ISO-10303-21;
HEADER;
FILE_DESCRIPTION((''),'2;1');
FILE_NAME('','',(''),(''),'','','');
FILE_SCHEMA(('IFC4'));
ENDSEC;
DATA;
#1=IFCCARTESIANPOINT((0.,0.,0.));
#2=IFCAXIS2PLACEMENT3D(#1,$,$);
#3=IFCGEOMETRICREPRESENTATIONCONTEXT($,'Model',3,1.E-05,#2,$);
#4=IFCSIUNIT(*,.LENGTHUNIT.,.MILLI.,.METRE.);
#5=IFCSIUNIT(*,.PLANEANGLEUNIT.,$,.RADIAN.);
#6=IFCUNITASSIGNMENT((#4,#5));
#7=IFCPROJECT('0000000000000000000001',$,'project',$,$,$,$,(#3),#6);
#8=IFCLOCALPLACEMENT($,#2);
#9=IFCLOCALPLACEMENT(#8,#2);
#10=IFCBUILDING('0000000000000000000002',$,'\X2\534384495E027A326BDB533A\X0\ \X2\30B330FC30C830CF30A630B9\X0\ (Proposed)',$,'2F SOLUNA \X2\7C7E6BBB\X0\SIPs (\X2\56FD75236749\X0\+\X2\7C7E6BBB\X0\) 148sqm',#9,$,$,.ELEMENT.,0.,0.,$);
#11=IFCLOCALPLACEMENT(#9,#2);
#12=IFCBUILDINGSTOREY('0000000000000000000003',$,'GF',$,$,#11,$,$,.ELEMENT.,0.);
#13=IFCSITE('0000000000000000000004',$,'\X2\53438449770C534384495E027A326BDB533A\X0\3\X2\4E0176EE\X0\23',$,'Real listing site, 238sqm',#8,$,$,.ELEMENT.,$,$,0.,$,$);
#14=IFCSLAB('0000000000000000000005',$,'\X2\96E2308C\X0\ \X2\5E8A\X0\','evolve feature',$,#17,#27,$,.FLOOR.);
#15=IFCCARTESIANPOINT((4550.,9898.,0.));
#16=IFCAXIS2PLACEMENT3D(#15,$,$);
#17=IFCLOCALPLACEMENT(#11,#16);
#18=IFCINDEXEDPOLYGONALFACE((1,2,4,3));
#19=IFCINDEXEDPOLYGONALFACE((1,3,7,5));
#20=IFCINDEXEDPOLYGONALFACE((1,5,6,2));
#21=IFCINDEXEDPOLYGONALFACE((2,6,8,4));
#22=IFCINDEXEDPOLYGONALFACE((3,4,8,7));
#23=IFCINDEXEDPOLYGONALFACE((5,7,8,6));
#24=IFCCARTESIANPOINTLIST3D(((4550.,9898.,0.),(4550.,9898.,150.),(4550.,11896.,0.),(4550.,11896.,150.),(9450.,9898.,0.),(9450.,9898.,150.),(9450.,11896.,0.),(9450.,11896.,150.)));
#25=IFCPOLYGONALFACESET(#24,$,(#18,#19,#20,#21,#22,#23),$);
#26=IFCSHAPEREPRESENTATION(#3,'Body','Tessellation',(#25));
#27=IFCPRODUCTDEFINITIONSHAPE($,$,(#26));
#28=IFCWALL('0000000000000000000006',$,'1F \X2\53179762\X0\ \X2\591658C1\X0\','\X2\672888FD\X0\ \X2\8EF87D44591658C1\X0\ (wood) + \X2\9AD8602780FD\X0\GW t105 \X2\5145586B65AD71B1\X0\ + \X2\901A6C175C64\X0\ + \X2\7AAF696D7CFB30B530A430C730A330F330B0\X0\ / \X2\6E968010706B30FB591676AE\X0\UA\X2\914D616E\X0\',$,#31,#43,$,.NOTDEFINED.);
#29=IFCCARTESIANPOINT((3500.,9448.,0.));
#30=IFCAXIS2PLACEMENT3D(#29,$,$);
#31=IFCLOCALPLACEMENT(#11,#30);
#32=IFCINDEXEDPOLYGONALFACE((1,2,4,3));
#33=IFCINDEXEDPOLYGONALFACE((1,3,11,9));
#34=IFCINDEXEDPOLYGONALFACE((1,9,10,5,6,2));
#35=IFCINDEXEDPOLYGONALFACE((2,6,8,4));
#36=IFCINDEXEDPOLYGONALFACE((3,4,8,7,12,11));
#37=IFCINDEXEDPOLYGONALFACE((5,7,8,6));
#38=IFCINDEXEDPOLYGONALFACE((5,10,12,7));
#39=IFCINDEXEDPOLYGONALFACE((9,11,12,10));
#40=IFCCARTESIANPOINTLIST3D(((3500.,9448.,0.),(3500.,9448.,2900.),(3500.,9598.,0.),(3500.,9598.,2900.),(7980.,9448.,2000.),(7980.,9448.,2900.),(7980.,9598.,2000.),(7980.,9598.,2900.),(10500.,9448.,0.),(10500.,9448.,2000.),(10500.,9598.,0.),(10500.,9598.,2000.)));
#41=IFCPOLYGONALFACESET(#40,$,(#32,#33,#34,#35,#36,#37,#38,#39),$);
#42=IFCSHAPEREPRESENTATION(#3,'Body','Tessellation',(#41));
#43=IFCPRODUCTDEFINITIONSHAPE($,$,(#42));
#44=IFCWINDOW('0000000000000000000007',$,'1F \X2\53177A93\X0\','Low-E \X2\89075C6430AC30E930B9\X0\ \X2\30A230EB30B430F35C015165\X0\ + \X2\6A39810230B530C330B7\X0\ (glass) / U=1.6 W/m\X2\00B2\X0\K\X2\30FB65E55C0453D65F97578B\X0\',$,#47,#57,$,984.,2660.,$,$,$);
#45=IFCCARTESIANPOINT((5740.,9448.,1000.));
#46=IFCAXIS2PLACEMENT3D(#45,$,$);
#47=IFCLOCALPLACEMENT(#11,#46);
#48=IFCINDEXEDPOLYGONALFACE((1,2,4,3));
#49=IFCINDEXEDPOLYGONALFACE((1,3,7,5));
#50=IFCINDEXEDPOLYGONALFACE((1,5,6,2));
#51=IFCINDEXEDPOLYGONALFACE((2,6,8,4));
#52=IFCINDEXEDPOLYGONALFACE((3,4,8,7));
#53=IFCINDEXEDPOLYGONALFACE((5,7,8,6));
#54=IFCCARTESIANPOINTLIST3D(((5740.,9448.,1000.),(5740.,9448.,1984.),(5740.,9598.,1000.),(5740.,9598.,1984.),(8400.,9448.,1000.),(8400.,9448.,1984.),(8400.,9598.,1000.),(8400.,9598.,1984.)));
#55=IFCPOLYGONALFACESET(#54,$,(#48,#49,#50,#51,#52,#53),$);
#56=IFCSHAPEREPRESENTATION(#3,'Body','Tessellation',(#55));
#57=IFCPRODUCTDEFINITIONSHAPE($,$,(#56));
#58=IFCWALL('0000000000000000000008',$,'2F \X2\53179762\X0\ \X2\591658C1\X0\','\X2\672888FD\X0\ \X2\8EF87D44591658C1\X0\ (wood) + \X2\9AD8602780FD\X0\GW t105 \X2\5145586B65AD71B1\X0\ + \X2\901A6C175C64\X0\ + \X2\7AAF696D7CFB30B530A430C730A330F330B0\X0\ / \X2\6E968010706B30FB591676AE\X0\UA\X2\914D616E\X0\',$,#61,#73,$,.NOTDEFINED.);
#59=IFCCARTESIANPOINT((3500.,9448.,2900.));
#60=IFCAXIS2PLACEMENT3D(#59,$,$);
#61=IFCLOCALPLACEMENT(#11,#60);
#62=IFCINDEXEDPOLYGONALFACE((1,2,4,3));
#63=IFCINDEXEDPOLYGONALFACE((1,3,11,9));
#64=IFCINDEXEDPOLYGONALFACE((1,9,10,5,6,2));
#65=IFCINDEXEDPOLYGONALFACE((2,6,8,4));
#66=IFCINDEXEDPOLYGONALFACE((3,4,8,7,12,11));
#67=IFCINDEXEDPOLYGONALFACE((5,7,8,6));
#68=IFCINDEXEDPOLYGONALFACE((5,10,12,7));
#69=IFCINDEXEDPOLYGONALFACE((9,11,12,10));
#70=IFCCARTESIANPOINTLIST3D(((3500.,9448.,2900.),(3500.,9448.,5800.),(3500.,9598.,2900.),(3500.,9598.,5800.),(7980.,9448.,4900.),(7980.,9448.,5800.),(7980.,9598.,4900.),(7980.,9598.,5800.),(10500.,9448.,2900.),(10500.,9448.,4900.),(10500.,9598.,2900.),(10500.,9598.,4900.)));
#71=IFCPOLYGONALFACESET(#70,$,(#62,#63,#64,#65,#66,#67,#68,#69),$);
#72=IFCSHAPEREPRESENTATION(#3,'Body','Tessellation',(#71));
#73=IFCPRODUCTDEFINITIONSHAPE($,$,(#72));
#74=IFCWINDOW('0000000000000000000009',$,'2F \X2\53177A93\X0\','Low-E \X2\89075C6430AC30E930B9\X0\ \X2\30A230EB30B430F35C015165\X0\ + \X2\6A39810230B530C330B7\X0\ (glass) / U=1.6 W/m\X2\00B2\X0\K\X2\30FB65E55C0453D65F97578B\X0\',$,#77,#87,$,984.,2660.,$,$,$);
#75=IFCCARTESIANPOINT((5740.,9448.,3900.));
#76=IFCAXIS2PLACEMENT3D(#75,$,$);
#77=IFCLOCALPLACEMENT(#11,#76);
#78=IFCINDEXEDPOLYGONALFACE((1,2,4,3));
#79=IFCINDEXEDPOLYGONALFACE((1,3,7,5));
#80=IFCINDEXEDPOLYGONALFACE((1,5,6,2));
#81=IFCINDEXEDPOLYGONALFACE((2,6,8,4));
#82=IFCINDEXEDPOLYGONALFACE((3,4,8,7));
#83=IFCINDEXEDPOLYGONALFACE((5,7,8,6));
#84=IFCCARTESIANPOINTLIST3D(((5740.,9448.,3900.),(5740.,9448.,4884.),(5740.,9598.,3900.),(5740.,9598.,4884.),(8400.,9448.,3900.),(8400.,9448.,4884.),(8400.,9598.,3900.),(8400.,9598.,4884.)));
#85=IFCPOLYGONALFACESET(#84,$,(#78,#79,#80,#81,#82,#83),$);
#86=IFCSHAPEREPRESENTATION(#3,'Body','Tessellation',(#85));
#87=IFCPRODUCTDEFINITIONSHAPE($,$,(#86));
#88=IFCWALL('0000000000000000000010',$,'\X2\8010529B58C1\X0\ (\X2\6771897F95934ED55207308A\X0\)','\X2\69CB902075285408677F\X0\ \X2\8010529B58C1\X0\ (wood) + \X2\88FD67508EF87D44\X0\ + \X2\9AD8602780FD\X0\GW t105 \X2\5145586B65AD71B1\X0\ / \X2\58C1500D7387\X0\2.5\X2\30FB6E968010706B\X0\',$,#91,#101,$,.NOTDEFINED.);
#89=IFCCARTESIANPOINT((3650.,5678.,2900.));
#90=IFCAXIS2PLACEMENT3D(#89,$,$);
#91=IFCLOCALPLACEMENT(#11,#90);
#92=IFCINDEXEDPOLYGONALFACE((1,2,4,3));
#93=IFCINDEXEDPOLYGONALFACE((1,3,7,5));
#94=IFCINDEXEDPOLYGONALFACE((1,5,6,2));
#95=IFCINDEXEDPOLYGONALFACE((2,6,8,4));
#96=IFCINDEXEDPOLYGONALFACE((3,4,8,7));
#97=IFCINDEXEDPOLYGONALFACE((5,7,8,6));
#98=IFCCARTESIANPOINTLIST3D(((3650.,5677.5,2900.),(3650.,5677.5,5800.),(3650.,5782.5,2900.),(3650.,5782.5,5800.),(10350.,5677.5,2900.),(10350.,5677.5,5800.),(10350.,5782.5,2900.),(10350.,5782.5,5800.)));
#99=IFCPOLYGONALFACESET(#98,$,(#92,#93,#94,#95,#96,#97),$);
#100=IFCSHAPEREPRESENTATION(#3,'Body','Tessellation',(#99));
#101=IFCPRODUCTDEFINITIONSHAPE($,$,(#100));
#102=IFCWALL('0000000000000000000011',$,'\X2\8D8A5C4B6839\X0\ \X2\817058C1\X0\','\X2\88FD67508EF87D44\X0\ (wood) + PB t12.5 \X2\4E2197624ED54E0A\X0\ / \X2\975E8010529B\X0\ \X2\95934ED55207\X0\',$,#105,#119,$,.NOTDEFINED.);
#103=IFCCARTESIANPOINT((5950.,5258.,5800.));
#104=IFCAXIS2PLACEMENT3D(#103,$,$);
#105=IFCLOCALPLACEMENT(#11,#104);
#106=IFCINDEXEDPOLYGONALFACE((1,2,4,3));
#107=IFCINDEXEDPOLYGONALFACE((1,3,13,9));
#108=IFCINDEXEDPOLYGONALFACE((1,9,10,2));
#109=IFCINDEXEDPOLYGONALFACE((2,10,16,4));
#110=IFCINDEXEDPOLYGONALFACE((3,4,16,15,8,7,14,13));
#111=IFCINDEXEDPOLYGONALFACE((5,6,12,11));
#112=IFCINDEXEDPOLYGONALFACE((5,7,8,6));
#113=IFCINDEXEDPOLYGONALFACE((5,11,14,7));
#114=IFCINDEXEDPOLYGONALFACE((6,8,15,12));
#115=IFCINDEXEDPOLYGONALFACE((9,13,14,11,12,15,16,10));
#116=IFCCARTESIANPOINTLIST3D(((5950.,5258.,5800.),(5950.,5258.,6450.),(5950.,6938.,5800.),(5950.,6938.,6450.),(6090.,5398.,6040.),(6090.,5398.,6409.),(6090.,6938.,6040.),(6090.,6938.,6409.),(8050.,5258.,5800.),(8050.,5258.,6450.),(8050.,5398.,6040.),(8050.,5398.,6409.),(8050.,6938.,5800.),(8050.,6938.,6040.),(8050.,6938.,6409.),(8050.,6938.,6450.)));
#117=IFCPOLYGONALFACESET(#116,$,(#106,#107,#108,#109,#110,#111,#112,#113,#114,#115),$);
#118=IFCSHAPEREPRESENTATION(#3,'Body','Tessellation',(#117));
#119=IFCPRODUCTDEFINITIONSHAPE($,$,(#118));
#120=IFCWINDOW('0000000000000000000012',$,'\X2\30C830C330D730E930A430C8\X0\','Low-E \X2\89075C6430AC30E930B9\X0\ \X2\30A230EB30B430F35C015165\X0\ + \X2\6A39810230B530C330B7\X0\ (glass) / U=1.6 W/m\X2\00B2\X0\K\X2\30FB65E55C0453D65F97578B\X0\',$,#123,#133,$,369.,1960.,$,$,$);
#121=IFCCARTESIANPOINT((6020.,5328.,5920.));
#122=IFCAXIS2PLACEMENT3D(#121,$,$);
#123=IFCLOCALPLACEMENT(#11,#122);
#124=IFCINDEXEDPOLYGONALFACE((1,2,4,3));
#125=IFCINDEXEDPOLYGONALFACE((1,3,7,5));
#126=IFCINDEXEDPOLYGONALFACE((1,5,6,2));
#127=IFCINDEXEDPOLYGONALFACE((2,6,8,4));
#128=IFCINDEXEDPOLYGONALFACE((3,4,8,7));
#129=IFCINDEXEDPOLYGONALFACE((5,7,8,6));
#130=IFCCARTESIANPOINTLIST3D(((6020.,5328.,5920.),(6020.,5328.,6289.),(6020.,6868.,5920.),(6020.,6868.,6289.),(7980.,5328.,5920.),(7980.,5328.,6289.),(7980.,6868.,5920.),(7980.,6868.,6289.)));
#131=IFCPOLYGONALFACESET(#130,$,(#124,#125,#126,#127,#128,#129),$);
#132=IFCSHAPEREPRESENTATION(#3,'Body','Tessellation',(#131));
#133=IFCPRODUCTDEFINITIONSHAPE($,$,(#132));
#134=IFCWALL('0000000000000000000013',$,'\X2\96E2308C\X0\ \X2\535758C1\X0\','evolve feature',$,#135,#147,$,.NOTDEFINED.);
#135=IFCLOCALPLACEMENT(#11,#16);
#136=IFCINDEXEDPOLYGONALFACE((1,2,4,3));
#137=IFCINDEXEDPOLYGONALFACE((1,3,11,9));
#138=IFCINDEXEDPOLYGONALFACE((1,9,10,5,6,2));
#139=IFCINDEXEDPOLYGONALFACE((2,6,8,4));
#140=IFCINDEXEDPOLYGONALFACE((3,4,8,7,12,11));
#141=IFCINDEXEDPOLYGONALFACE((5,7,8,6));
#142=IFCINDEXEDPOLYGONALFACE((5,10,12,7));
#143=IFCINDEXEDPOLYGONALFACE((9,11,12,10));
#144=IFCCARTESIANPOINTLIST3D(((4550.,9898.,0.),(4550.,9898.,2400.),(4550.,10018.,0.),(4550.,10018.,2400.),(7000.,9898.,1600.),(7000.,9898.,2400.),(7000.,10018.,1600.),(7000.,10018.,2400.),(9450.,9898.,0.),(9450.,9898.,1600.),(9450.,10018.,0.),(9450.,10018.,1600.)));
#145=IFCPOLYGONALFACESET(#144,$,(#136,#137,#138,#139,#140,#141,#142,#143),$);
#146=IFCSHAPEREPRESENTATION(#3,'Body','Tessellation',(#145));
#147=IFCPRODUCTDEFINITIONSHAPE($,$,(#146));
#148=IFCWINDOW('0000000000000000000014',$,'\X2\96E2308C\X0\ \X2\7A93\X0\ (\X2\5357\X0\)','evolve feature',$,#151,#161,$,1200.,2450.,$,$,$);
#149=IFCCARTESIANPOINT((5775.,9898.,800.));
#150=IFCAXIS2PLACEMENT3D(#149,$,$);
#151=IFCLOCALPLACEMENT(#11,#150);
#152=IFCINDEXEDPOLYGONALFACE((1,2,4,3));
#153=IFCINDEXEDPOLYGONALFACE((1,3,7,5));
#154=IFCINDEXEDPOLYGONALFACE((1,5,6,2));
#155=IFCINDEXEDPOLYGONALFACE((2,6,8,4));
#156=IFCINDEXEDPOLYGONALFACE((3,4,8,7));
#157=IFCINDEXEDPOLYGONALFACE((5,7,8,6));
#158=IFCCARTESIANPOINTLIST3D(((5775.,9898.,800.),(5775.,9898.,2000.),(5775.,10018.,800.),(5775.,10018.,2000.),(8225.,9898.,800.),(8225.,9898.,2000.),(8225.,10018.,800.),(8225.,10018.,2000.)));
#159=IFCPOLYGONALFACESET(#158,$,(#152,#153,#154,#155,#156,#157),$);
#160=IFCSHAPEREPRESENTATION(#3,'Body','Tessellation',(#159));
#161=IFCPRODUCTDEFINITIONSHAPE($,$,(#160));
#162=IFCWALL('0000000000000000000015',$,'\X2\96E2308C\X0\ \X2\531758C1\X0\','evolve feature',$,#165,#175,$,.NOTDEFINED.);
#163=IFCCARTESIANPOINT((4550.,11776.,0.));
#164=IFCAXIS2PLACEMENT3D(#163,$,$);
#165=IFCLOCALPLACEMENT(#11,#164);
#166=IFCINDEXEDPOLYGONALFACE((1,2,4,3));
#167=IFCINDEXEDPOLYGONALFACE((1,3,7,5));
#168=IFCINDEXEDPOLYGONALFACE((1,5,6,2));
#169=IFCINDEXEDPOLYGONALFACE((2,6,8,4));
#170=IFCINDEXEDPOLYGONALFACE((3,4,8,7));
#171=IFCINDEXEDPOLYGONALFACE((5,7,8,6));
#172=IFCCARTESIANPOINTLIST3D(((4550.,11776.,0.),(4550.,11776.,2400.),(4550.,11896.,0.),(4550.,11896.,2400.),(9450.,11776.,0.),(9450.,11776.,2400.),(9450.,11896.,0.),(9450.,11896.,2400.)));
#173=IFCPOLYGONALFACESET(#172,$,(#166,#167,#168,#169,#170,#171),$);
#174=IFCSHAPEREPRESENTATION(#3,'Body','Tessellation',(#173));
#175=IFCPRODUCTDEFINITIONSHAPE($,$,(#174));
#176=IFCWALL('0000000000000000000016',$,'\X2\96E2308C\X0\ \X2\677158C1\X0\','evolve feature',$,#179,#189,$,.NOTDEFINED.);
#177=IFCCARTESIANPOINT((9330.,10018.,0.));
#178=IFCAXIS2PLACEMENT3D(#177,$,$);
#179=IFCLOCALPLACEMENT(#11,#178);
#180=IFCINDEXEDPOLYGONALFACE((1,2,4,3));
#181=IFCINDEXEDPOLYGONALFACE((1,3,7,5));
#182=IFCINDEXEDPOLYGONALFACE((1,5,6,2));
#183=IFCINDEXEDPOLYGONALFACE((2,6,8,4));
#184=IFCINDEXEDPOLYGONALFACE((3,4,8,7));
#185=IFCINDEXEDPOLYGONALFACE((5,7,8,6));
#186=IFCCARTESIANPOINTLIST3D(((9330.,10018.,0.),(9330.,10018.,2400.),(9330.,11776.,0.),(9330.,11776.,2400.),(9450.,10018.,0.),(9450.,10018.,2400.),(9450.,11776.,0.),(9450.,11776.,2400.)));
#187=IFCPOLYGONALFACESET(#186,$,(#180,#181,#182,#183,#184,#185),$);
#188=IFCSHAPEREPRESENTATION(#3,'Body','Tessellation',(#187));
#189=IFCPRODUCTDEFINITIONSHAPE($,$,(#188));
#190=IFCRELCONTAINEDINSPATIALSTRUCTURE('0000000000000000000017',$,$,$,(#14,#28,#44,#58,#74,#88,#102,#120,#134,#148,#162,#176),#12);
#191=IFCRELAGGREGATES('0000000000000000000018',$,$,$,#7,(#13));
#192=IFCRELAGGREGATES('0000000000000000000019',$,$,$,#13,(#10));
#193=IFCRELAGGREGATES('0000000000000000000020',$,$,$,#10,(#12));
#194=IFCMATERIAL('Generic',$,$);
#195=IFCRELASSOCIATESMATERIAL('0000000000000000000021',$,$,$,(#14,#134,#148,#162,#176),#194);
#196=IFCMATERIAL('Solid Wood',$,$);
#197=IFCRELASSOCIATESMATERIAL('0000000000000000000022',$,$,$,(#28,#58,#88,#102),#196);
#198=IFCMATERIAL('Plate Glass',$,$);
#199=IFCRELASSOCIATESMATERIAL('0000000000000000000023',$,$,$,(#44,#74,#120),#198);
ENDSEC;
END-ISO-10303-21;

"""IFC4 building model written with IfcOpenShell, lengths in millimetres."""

from ifc_helpers import new_model, si_unit, frame, frame_2d, origin, place, context, project, spatial, rectangle, extrude, material, element, fill, save


model = new_model("IFC4")

# Units and contexts
model_context = context("Model", 3, precision=1e-05, world=origin())
ifc_project = project(units=[si_unit("LENGTHUNIT", "METRE", prefix="MILLI"), si_unit("PLANEANGLEUNIT", "RADIAN")], contexts=[model_context])

# Site, building, storey
site_placement = place(None, origin())
site = spatial("IfcSite", under=ifc_project, at=site_placement, Name="千葉県千葉市稲毛区3丁目23", ObjectType="Real listing site, 238sqm", CompositionType="ELEMENT", RefElevation=0.0)
building_placement = place(site_placement, origin())
building = spatial("IfcBuilding", under=site, at=building_placement, Name="千葉市稲毛区 コートハウス (Proposed)", ObjectType="2F SOLUNA 籾殻SIPs (国産杉+籾殻) 148sqm", CompositionType="ELEMENT", ElevationOfRefHeight=0.0, ElevationOfTerrain=0.0)
storey_placement = place(building_placement, origin())
storey = spatial("IfcBuildingStorey", under=building, at=storey_placement, Name="GF", CompositionType="ELEMENT", Elevation=0.0)

# Slab
ifc_material_1 = material(Name="Generic")
slab_placement = place(storey_placement, frame((4550.0, 9898.0, 0.0)))
element("IfcSlab", 1, at=slab_placement, inside=storey, material=ifc_material_1, Name="離れ 床", Description="evolve feature", PredefinedType="FLOOR", context=model_context, shape_type="SweptSolid", body=[
    extrude(rectangle(XDim=4900.0, YDim=1998.0, at=frame_2d((2450.0, 999.0))), frame((4550.0, 9898.0, 0.0)), (0.0, 0.0, 1.0), 150.0),
])

# Wall, opening, window
ifc_material_2 = material(Name="Solid Wood")
wall_1_placement = place(storey_placement, frame((3500.0, 9448.0, 0.0)))
wall_1 = element("IfcWall", 2, at=wall_1_placement, inside=storey, material=ifc_material_2, Name="1F 北面 外壁", Description="木製 軸組外壁 (wood) + 高性能GW t105 充填断熱 + 通気層 + 窯業系サイディング / 準耐火・外皮UA配慮", PredefinedType="NOTDEFINED", context=model_context, shape_type="SweptSolid", body=[
    extrude(rectangle(XDim=7000.0, YDim=150.0, at=frame_2d((3500.0, 75.0))), frame((3500.0, 9448.0, 0.0)), (0.0, 0.0, 1.0), 2900.0),
])
opening_1_placement = place(storey_placement, frame((5740.0, 9448.0, 1000.0)))
opening_1 = element("IfcOpeningElement", 3, at=opening_1_placement, cuts=wall_1, PredefinedType="NOTDEFINED", context=model_context, shape_type="SweptSolid", body=[
    extrude(rectangle(XDim=2660.0, YDim=150.0, at=frame_2d((1330.0, 75.0))), frame((5740.0, 9448.0, 1000.0)), (0.0, 0.0, 1.0), 984.0),
])
ifc_material_3 = material(Name="Plate Glass")
window_1_placement = place(storey_placement, frame((5740.0, 9448.0, 1000.0)))
window_1 = element("IfcWindow", 4, at=window_1_placement, inside=storey, material=ifc_material_3, Name="1F 北窓", Description="Low-E 複層ガラス アルゴン封入 + 樹脂サッシ (glass) / U=1.6 W/m²K・日射取得型", OverallHeight=984.0, OverallWidth=2660.0, context=model_context, shape_type="SweptSolid", body=[
    extrude(rectangle(XDim=2660.0, YDim=150.0, at=frame_2d((1330.0, 75.0))), frame((5740.0, 9448.0, 1000.0)), (0.0, 0.0, 1.0), 984.0),
])
fill(opening_1, window_1)

# Wall, opening, window
wall_2_placement = place(storey_placement, frame((3500.0, 9448.0, 2900.0)))
wall_2 = element("IfcWall", 5, at=wall_2_placement, inside=storey, material=ifc_material_2, Name="2F 北面 外壁", Description="木製 軸組外壁 (wood) + 高性能GW t105 充填断熱 + 通気層 + 窯業系サイディング / 準耐火・外皮UA配慮", PredefinedType="NOTDEFINED", context=model_context, shape_type="SweptSolid", body=[
    extrude(rectangle(XDim=7000.0, YDim=150.0, at=frame_2d((3500.0, 75.0))), frame((3500.0, 9448.0, 2900.0)), (0.0, 0.0, 1.0), 2900.0),
])
opening_2_placement = place(storey_placement, frame((5740.0, 9448.0, 3900.0)))
opening_2 = element("IfcOpeningElement", 6, at=opening_2_placement, cuts=wall_2, PredefinedType="NOTDEFINED", context=model_context, shape_type="SweptSolid", body=[
    extrude(rectangle(XDim=2660.0, YDim=150.0, at=frame_2d((1330.0, 75.0))), frame((5740.0, 9448.0, 3900.0)), (0.0, 0.0, 1.0), 984.0),
])
window_2_placement = place(storey_placement, frame((5740.0, 9448.0, 3900.0)))
window_2 = element("IfcWindow", 7, at=window_2_placement, inside=storey, material=ifc_material_3, Name="2F 北窓", Description="Low-E 複層ガラス アルゴン封入 + 樹脂サッシ (glass) / U=1.6 W/m²K・日射取得型", OverallHeight=984.0, OverallWidth=2660.0, context=model_context, shape_type="SweptSolid", body=[
    extrude(rectangle(XDim=2660.0, YDim=150.0, at=frame_2d((1330.0, 75.0))), frame((5740.0, 9448.0, 3900.0)), (0.0, 0.0, 1.0), 984.0),
])
fill(opening_2, window_2)

# Wall
wall_3_placement = place(storey_placement, frame((3650.0, 5678.0, 2900.0)))
element("IfcWall", 8, at=wall_3_placement, inside=storey, material=ifc_material_2, Name="耐力壁 (東西間仕切り)", Description="構造用合板 耐力壁 (wood) + 製材軸組 + 高性能GW t105 充填断熱 / 壁倍率2.5・準耐火", PredefinedType="NOTDEFINED", context=model_context, shape_type="SweptSolid", body=[
    extrude(rectangle(XDim=6700.0, YDim=105.0, at=frame_2d((3350.0, 52.0))), frame((3650.0, 5678.0, 2900.0)), (0.0, 0.0, 1.0), 2900.0),
])

# Walls, openings, windows
wall_4_placement = place(storey_placement, frame((5950.0, 5258.0, 5800.0)))
wall_4 = element("IfcWall", 9, at=wall_4_placement, inside=storey, material=ifc_material_2, Name="越屋根 腰壁", Description="製材軸組 (wood) + PB t12.5 両面仕上 / 非耐力 間仕切", PredefinedType="NOTDEFINED", context=model_context, shape_type="SweptSolid", body=[
    extrude(rectangle(XDim=2100.0, YDim=1680.0, at=frame_2d((1050.0, 840.0))), frame((5950.0, 5258.0, 5800.0)), (0.0, 0.0, 1.0), 650.0),
])
opening_3_placement = place(storey_placement, frame((6020.0, 5328.0, 5920.0)))
opening_3 = element("IfcOpeningElement", 10, at=opening_3_placement, cuts=wall_4, PredefinedType="NOTDEFINED", context=model_context, shape_type="SweptSolid", body=[
    extrude(rectangle(XDim=1960.0, YDim=1540.0, at=frame_2d((980.0, 770.0))), frame((6020.0, 5328.0, 5920.0)), (0.0, 0.0, 1.0), 369.0),
])
window_3_placement = place(storey_placement, frame((6020.0, 5328.0, 5920.0)))
window_3 = element("IfcWindow", 11, at=window_3_placement, inside=storey, material=ifc_material_3, Name="トップライト", Description="Low-E 複層ガラス アルゴン封入 + 樹脂サッシ (glass) / U=1.6 W/m²K・日射取得型", OverallHeight=369.0, OverallWidth=1960.0, context=model_context, shape_type="SweptSolid", body=[
    extrude(rectangle(XDim=1960.0, YDim=1540.0, at=frame_2d((980.0, 770.0))), frame((6020.0, 5328.0, 5920.0)), (0.0, 0.0, 1.0), 369.0),
])
fill(opening_3, window_3)
wall_5_placement = place(storey_placement, frame((4550.0, 9898.0, 0.0)))
wall_5 = element("IfcWall", 12, at=wall_5_placement, inside=storey, material=ifc_material_1, Name="離れ 南壁", Description="evolve feature", PredefinedType="NOTDEFINED", context=model_context, shape_type="SweptSolid", body=[
    extrude(rectangle(XDim=4900.0, YDim=120.0, at=frame_2d((2450.0, 60.0))), frame((4550.0, 9898.0, 0.0)), (0.0, 0.0, 1.0), 2400.0),
])
opening_4_placement = place(storey_placement, frame((5775.0, 9898.0, 800.0)))
opening_4 = element("IfcOpeningElement", 13, at=opening_4_placement, cuts=wall_5, PredefinedType="NOTDEFINED", context=model_context, shape_type="SweptSolid", body=[
    extrude(rectangle(XDim=2450.0, YDim=120.0, at=frame_2d((1225.0, 60.0))), frame((5775.0, 9898.0, 800.0)), (0.0, 0.0, 1.0), 1200.0),
])
window_4_placement = place(storey_placement, frame((5775.0, 9898.0, 800.0)))
window_4 = element("IfcWindow", 14, at=window_4_placement, inside=storey, material=ifc_material_1, Name="離れ 窓 (南)", Description="evolve feature", OverallHeight=1200.0, OverallWidth=2450.0, context=model_context, shape_type="SweptSolid", body=[
    extrude(rectangle(XDim=2450.0, YDim=120.0, at=frame_2d((1225.0, 60.0))), frame((5775.0, 9898.0, 800.0)), (0.0, 0.0, 1.0), 1200.0),
])
fill(opening_4, window_4)

# Walls
wall_6_placement = place(storey_placement, frame((4550.0, 11776.0, 0.0)))
element("IfcWall", 15, at=wall_6_placement, inside=storey, material=ifc_material_1, Name="離れ 北壁", Description="evolve feature", PredefinedType="NOTDEFINED", context=model_context, shape_type="SweptSolid", body=[
    extrude(rectangle(XDim=4900.0, YDim=120.0, at=frame_2d((2450.0, 60.0))), frame((4550.0, 11776.0, 0.0)), (0.0, 0.0, 1.0), 2400.0),
])
wall_7_placement = place(storey_placement, frame((9330.0, 10018.0, 0.0)))
element("IfcWall", 16, at=wall_7_placement, inside=storey, material=ifc_material_1, Name="離れ 東壁", Description="evolve feature", PredefinedType="NOTDEFINED", context=model_context, shape_type="SweptSolid", body=[
    extrude(rectangle(XDim=120.0, YDim=1758.0, at=frame_2d((60.0, 879.0))), frame((9330.0, 10018.0, 0.0)), (0.0, 0.0, 1.0), 2400.0),
])

save(model, "model.ifc")
